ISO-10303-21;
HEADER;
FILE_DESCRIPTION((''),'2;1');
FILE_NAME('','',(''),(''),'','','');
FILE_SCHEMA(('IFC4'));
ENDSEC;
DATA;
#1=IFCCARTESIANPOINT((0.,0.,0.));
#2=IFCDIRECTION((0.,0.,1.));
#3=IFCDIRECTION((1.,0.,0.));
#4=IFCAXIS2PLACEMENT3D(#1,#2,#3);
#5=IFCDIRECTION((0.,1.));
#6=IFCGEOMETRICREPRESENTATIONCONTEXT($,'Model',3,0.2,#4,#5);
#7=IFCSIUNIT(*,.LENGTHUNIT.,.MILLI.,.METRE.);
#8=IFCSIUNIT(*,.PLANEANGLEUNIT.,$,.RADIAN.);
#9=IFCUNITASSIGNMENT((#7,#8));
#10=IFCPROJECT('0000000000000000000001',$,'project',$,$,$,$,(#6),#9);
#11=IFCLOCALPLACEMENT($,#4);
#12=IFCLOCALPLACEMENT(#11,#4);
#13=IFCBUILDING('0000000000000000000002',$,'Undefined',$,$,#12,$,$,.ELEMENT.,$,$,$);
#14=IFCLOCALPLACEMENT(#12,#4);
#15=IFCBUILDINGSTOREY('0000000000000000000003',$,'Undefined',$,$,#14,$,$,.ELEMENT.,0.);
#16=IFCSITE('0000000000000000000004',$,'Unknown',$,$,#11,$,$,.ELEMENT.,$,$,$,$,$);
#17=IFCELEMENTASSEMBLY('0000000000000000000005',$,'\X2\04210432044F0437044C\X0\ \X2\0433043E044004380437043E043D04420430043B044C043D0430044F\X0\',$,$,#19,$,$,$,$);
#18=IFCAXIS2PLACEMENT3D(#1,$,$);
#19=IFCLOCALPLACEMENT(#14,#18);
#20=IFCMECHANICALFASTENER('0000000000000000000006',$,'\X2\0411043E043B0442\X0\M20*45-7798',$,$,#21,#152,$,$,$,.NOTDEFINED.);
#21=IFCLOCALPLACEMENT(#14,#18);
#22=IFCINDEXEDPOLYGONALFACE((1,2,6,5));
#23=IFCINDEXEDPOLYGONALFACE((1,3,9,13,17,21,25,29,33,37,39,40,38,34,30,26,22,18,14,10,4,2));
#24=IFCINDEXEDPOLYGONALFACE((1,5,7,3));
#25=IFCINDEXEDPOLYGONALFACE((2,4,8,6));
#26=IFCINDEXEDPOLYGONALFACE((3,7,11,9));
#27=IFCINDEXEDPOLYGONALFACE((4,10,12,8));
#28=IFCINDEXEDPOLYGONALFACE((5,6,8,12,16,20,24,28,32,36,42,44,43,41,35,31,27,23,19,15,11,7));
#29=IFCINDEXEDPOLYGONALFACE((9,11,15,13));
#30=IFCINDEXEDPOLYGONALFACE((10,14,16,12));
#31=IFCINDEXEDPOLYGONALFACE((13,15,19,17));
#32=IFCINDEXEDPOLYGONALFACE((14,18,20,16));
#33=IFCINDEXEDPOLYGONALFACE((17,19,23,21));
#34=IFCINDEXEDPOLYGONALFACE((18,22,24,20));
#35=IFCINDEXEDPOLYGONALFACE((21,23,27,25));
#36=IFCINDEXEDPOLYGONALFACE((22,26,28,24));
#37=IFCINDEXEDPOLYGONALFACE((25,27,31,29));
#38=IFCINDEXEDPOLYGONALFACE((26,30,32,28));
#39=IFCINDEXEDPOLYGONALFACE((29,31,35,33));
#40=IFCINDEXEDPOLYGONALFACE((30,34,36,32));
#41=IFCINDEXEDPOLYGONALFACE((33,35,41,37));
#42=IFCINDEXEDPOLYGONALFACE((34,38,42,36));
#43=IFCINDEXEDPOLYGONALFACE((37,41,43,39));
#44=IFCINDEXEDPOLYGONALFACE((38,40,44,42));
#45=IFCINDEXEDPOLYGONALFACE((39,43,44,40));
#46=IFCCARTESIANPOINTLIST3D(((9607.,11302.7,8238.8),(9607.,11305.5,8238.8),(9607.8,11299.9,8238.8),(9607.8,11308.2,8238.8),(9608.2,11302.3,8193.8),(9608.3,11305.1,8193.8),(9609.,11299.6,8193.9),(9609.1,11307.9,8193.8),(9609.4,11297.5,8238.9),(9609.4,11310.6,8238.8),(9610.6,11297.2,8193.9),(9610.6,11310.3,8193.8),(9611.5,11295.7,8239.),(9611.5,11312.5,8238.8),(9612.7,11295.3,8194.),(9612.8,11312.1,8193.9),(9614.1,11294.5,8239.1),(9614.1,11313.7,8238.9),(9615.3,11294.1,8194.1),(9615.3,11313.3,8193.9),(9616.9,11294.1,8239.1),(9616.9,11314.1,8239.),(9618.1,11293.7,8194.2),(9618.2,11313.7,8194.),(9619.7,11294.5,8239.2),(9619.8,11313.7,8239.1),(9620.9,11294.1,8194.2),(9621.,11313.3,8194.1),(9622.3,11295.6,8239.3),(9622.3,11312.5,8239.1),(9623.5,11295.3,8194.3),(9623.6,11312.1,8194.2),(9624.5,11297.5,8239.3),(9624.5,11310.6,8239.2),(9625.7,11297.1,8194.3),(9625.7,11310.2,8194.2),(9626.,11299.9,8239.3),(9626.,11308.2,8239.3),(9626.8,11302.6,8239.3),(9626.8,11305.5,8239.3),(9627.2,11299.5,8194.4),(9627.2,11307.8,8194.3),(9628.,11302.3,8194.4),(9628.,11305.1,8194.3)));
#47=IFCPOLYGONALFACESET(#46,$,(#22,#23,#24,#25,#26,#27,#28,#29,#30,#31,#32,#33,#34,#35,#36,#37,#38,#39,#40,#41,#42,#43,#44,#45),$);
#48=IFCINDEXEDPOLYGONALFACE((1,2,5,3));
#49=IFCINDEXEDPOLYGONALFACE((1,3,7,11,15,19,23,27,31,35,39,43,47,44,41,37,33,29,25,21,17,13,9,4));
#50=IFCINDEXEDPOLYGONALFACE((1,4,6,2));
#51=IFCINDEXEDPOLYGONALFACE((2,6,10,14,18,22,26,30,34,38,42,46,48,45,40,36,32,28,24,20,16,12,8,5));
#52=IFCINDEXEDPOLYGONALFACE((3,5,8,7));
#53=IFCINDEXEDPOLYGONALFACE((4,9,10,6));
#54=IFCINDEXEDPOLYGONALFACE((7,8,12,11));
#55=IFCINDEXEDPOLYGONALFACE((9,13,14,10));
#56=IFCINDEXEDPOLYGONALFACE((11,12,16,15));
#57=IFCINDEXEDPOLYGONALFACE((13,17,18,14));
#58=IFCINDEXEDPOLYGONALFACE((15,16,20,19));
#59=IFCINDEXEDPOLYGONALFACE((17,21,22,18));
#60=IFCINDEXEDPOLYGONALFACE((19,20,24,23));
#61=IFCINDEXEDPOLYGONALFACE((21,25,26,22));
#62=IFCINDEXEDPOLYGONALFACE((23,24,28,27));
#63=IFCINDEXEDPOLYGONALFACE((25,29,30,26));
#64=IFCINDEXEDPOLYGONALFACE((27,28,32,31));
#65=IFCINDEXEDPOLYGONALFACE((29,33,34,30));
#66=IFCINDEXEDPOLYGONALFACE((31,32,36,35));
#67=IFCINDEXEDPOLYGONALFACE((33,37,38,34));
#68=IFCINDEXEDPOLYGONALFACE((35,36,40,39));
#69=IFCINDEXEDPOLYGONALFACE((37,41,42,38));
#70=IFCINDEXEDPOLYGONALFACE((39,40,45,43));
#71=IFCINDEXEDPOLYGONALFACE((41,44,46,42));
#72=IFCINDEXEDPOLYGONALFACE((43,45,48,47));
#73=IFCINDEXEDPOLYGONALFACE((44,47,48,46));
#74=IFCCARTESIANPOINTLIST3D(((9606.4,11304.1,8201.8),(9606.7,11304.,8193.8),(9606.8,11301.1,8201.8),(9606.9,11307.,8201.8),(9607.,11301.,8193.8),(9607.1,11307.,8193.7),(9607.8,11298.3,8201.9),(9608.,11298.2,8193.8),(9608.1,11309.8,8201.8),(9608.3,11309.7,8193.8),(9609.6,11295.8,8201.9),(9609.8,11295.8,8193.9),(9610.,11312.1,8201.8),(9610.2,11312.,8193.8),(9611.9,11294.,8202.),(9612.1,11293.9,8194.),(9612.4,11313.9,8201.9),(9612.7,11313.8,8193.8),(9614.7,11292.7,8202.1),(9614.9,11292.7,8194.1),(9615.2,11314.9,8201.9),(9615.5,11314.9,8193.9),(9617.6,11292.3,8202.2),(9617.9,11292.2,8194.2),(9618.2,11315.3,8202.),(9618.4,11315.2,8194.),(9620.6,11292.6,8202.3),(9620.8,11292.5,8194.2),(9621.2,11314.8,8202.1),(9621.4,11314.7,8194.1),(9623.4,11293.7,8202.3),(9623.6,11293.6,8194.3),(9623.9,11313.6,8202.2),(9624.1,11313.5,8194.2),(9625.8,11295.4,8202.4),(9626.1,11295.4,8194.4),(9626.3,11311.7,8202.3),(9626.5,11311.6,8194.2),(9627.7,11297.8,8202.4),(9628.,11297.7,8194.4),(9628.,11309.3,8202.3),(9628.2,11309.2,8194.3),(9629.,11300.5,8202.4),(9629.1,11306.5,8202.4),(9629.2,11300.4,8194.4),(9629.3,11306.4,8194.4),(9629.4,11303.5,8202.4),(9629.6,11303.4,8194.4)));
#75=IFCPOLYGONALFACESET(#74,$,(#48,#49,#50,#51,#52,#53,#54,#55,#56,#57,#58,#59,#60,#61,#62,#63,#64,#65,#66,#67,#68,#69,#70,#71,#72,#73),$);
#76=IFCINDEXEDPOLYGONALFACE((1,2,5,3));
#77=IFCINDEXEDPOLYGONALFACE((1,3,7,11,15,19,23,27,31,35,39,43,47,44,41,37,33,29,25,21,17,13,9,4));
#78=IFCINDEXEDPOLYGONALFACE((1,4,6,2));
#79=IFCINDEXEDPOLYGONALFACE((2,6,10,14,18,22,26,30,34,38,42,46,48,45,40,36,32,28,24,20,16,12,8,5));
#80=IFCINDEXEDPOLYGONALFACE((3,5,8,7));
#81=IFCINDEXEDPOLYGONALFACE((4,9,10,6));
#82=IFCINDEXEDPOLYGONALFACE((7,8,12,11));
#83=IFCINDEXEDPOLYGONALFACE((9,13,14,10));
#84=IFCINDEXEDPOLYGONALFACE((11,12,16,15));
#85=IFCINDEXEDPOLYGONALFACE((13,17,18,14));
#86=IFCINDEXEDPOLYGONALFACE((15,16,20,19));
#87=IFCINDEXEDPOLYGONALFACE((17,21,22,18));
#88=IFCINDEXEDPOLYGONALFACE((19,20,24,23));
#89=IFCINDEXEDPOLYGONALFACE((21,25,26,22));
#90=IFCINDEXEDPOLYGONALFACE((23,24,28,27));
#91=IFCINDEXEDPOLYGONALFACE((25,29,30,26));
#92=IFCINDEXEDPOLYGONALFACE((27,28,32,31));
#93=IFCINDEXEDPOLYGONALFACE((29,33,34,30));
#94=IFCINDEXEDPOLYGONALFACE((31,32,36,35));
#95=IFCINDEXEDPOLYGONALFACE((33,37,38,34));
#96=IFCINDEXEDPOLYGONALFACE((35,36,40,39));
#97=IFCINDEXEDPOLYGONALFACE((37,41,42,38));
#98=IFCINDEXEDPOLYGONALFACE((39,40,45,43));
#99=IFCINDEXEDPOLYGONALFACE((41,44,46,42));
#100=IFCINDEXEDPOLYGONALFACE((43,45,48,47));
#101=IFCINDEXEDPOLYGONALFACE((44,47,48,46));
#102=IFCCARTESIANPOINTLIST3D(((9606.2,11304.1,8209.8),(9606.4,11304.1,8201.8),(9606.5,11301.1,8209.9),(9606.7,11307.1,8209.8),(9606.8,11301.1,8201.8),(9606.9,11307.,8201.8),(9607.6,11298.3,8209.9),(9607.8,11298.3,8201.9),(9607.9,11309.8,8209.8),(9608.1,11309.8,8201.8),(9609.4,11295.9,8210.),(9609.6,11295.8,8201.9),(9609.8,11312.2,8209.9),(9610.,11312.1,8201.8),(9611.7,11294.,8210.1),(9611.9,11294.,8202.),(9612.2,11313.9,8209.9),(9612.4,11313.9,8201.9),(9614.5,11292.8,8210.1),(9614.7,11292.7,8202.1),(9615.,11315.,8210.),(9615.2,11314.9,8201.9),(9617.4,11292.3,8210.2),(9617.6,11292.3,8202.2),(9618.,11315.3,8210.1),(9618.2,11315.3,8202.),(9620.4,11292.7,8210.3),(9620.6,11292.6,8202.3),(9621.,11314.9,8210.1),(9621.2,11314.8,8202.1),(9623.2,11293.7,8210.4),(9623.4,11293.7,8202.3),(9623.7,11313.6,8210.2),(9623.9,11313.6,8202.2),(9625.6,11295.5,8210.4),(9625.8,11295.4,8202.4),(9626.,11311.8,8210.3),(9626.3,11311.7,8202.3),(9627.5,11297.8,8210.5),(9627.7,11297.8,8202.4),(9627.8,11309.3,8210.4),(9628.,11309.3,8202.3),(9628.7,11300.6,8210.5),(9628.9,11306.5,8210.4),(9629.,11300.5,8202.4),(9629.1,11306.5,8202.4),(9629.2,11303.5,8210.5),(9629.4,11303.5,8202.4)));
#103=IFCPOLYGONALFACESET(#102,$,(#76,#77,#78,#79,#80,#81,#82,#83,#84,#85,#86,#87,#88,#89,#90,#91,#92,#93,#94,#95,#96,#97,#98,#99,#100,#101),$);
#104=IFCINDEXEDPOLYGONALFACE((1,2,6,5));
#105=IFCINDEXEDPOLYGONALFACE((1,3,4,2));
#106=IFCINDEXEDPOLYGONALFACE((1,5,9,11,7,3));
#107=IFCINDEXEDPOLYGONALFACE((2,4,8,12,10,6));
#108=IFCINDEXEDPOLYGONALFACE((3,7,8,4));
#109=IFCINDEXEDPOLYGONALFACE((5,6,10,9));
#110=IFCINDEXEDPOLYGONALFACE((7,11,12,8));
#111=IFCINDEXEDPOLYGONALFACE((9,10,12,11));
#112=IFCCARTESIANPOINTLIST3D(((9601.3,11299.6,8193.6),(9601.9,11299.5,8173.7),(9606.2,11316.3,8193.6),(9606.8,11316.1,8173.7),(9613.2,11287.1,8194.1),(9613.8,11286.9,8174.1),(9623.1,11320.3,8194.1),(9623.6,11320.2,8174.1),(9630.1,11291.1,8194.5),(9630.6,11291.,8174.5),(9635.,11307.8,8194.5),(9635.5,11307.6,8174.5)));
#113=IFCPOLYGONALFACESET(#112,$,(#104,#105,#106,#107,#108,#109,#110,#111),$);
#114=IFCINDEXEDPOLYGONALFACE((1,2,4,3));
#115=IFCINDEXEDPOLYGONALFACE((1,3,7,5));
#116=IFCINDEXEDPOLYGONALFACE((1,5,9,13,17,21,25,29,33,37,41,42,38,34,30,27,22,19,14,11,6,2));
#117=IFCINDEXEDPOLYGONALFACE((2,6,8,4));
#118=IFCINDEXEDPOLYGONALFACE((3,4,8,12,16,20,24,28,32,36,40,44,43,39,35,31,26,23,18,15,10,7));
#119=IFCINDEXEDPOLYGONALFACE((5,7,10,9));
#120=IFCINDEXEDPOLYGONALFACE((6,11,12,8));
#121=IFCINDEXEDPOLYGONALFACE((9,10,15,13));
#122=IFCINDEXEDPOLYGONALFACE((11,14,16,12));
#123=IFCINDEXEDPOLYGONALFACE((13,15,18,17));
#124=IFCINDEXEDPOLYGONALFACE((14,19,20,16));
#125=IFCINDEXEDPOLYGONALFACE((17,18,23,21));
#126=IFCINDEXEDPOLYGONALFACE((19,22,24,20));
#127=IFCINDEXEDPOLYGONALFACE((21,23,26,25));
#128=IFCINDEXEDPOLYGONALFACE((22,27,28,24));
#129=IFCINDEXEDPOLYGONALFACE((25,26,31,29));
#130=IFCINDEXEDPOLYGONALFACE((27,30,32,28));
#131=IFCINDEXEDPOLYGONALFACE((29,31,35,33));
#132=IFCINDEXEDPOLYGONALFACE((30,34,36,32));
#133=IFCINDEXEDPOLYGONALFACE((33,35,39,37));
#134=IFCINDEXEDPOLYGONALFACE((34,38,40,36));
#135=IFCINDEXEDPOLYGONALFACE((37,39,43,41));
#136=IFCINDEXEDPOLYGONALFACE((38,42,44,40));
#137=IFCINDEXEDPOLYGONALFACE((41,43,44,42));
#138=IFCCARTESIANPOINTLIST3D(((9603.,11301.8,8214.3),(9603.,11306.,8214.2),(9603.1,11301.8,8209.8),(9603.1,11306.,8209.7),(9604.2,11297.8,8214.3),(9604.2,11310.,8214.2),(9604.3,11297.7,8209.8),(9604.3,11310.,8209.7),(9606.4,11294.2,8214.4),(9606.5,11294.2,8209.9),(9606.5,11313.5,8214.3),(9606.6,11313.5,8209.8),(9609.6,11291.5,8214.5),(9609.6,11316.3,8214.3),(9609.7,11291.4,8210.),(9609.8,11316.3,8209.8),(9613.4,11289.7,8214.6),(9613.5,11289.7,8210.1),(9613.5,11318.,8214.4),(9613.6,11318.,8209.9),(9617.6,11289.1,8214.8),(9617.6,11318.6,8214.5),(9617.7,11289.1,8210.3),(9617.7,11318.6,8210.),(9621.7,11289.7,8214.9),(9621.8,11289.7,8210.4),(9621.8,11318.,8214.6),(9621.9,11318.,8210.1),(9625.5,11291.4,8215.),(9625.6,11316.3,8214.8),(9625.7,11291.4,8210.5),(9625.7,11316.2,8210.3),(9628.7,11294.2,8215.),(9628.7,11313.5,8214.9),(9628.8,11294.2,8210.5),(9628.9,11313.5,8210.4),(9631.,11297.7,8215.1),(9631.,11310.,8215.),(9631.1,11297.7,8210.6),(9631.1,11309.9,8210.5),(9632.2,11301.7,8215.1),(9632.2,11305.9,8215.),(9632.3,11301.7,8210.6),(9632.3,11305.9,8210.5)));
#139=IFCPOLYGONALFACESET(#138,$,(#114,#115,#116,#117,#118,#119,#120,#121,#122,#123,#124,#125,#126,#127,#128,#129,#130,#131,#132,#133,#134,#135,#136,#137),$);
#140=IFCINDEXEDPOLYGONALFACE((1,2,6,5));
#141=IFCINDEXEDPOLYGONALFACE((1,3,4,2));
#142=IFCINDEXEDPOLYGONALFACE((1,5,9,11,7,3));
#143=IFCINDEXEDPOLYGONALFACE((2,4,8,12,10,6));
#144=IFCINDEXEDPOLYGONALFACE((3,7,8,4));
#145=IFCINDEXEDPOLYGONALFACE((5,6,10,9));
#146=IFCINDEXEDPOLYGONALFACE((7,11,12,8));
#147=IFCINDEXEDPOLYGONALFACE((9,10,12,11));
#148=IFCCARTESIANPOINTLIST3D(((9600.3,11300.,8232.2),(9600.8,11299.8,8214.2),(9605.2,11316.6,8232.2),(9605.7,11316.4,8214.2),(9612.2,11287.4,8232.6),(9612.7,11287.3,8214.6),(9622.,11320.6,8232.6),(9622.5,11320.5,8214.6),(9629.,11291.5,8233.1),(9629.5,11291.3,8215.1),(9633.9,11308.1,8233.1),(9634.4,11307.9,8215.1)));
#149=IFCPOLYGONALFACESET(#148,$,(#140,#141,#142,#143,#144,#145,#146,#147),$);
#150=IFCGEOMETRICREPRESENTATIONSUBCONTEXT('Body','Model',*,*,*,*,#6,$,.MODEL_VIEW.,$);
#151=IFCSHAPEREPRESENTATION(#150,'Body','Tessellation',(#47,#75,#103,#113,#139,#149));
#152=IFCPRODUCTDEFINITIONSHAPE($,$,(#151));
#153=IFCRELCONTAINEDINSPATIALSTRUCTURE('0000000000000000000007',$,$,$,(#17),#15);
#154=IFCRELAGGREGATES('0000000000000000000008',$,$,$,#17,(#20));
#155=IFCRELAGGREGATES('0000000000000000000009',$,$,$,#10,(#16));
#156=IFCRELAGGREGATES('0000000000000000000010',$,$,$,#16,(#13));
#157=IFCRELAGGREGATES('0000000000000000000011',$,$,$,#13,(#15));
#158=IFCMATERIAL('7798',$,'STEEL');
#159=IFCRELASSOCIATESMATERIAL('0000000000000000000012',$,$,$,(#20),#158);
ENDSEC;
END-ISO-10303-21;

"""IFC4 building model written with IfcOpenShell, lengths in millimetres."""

from ifc_helpers import new_model, si_unit, direction, frame, origin_with_axes, place, context, subcontext, project, spatial, line, arc, indexed_curve, outline, extrude, source, transform, mapped, material, element, aggregate, save


model = new_model("IFC4")

# Units and contexts
model_context = context("Model", 3, precision=0.2, world=origin_with_axes(), true_north=direction((0.0, 1.0)))
body_context = subcontext(model_context, "Body", "Model", "MODEL_VIEW")
ifc_project = project(units=[si_unit("LENGTHUNIT", "METRE", prefix="MILLI"), si_unit("PLANEANGLEUNIT", "RADIAN")], contexts=[model_context])

# Site, building, storey
site_placement = place(None, origin_with_axes())
site = spatial("IfcSite", under=ifc_project, at=site_placement, Name="Unknown", CompositionType="ELEMENT")
building_placement = place(site_placement, origin_with_axes())
building = spatial("IfcBuilding", under=site, at=building_placement, Name="Undefined", CompositionType="ELEMENT")
storey_placement = place(building_placement, origin_with_axes())
storey = spatial("IfcBuildingStorey", under=building, at=storey_placement, Name="Undefined", CompositionType="ELEMENT", Elevation=0.0)

# Element assembly
assembly_1_placement = place(storey_placement, frame((8657.9, 11587.5, 8177.8), z_axis=(-0.28473, -0.95385, 0.095385), x_axis=(0.958608, -0.283317, 0.028332)))
assembly_1 = element("IfcElementAssembly", 1, at=assembly_1_placement, inside=storey, Name="Связь горизонтальная")

# Shared definitions
ifc_material_1 = material(Name="7798", Category="STEEL")

# Mechanical fastener
shared_shape_1 = source(origin_with_axes(), body_context, "Body", "SweptSolid", [
    extrude(outline(indexed_curve([(10.0, 0.0), (0.0, 10.0), (-10.0, 0.0), (0.0, -10.0)], segments=[arc(1, 2, 3), arc(3, 4, 1)])), frame((0.0, 0.0, 12.1), z_axis=(0.0, 0.0, -1.0), x_axis=(0.0, 1.0, 0.0)), (0.0, 0.0, 1.0), 45.0),
    extrude(outline(indexed_curve([(0.0, 11.5), (8.1, 8.1), (11.5, 0.0), (8.1, -8.1), (0.0, -11.5), (-1.0, -11.5), (-11.5, 0.0), (-8.1, 8.1)], segments=[arc(1, 2, 3), arc(3, 4, 5), arc(5, 6, 7), arc(7, 8, 1)])), frame((0.0, 0.0, 12.1), z_axis=(0.0, 0.0, -1.0), x_axis=(0.0, 1.0, 0.0)), (0.0, 0.0, 1.0), 8.0),
    extrude(outline(indexed_curve([(0.0, 11.5), (8.1, 8.1), (11.5, 0.0), (8.1, -8.1), (0.0, -11.5), (-1.0, -11.5), (-11.5, 0.0), (-8.1, 8.1)], segments=[arc(1, 2, 3), arc(3, 4, 5), arc(5, 6, 7), arc(7, 8, 1)])), frame((0.0, 0.0, 4.0), z_axis=(0.0, 0.0, -1.0), x_axis=(0.0, 1.0, 0.0)), (0.0, 0.0, 1.0), 8.0),
    extrude(outline(indexed_curve([(17.3, 0.0), (8.7, 15.0), (-8.7, 15.0), (-17.3, 0.0), (-8.7, -15.0), (8.7, -15.0)], segments=[line(1, 2, 3, 4, 5, 6, 1)])), frame((0.0, 0.0, 32.1), z_axis=(0.0, 0.0, -1.0), x_axis=(0.0, 1.0, 0.0)), (0.0, 0.0, 1.0), 20.0),
    extrude(outline(indexed_curve([(14.8, 0.0), (0.0, 14.8), (-14.8, 0.0), (0.0, -14.8)], segments=[arc(1, 2, 3), arc(3, 4, 1)])), frame((0.0, 0.0, -4.0), z_axis=(0.0, 0.0, -1.0), x_axis=(0.0, 1.0, 0.0)), (0.0, 0.0, 1.0), 4.5),
    extrude(outline(indexed_curve([(17.3, 0.0), (8.7, 15.0), (-8.7, 15.0), (-17.3, 0.0), (-8.7, -15.0), (8.7, -15.0)], segments=[line(1, 2, 3, 4, 5, 6, 1)])), frame((0.0, 0.0, -8.5), z_axis=(0.0, 0.0, -1.0), x_axis=(0.0, 1.0, 0.0)), (0.0, 0.0, 1.0), 18.0),
])
mechanical_fastener_1_placement = place(assembly_1_placement, frame((1001.3, 0.0, 0.0), z_axis=(0.0, -0.995437, -0.095423), x_axis=(-1.0, 0.0, 0.0)))
mechanical_fastener_1 = element("IfcMechanicalFastener", 2, at=mechanical_fastener_1_placement, material=ifc_material_1, Name="БолтM20*45-7798", PredefinedType="NOTDEFINED", context=body_context, shape_type="MappedRepresentation", body=[
    mapped(shared_shape_1, transform((0.0, 0.0, 0.0))),
])
aggregate(assembly_1, [mechanical_fastener_1])

save(model, "model.ifc")
